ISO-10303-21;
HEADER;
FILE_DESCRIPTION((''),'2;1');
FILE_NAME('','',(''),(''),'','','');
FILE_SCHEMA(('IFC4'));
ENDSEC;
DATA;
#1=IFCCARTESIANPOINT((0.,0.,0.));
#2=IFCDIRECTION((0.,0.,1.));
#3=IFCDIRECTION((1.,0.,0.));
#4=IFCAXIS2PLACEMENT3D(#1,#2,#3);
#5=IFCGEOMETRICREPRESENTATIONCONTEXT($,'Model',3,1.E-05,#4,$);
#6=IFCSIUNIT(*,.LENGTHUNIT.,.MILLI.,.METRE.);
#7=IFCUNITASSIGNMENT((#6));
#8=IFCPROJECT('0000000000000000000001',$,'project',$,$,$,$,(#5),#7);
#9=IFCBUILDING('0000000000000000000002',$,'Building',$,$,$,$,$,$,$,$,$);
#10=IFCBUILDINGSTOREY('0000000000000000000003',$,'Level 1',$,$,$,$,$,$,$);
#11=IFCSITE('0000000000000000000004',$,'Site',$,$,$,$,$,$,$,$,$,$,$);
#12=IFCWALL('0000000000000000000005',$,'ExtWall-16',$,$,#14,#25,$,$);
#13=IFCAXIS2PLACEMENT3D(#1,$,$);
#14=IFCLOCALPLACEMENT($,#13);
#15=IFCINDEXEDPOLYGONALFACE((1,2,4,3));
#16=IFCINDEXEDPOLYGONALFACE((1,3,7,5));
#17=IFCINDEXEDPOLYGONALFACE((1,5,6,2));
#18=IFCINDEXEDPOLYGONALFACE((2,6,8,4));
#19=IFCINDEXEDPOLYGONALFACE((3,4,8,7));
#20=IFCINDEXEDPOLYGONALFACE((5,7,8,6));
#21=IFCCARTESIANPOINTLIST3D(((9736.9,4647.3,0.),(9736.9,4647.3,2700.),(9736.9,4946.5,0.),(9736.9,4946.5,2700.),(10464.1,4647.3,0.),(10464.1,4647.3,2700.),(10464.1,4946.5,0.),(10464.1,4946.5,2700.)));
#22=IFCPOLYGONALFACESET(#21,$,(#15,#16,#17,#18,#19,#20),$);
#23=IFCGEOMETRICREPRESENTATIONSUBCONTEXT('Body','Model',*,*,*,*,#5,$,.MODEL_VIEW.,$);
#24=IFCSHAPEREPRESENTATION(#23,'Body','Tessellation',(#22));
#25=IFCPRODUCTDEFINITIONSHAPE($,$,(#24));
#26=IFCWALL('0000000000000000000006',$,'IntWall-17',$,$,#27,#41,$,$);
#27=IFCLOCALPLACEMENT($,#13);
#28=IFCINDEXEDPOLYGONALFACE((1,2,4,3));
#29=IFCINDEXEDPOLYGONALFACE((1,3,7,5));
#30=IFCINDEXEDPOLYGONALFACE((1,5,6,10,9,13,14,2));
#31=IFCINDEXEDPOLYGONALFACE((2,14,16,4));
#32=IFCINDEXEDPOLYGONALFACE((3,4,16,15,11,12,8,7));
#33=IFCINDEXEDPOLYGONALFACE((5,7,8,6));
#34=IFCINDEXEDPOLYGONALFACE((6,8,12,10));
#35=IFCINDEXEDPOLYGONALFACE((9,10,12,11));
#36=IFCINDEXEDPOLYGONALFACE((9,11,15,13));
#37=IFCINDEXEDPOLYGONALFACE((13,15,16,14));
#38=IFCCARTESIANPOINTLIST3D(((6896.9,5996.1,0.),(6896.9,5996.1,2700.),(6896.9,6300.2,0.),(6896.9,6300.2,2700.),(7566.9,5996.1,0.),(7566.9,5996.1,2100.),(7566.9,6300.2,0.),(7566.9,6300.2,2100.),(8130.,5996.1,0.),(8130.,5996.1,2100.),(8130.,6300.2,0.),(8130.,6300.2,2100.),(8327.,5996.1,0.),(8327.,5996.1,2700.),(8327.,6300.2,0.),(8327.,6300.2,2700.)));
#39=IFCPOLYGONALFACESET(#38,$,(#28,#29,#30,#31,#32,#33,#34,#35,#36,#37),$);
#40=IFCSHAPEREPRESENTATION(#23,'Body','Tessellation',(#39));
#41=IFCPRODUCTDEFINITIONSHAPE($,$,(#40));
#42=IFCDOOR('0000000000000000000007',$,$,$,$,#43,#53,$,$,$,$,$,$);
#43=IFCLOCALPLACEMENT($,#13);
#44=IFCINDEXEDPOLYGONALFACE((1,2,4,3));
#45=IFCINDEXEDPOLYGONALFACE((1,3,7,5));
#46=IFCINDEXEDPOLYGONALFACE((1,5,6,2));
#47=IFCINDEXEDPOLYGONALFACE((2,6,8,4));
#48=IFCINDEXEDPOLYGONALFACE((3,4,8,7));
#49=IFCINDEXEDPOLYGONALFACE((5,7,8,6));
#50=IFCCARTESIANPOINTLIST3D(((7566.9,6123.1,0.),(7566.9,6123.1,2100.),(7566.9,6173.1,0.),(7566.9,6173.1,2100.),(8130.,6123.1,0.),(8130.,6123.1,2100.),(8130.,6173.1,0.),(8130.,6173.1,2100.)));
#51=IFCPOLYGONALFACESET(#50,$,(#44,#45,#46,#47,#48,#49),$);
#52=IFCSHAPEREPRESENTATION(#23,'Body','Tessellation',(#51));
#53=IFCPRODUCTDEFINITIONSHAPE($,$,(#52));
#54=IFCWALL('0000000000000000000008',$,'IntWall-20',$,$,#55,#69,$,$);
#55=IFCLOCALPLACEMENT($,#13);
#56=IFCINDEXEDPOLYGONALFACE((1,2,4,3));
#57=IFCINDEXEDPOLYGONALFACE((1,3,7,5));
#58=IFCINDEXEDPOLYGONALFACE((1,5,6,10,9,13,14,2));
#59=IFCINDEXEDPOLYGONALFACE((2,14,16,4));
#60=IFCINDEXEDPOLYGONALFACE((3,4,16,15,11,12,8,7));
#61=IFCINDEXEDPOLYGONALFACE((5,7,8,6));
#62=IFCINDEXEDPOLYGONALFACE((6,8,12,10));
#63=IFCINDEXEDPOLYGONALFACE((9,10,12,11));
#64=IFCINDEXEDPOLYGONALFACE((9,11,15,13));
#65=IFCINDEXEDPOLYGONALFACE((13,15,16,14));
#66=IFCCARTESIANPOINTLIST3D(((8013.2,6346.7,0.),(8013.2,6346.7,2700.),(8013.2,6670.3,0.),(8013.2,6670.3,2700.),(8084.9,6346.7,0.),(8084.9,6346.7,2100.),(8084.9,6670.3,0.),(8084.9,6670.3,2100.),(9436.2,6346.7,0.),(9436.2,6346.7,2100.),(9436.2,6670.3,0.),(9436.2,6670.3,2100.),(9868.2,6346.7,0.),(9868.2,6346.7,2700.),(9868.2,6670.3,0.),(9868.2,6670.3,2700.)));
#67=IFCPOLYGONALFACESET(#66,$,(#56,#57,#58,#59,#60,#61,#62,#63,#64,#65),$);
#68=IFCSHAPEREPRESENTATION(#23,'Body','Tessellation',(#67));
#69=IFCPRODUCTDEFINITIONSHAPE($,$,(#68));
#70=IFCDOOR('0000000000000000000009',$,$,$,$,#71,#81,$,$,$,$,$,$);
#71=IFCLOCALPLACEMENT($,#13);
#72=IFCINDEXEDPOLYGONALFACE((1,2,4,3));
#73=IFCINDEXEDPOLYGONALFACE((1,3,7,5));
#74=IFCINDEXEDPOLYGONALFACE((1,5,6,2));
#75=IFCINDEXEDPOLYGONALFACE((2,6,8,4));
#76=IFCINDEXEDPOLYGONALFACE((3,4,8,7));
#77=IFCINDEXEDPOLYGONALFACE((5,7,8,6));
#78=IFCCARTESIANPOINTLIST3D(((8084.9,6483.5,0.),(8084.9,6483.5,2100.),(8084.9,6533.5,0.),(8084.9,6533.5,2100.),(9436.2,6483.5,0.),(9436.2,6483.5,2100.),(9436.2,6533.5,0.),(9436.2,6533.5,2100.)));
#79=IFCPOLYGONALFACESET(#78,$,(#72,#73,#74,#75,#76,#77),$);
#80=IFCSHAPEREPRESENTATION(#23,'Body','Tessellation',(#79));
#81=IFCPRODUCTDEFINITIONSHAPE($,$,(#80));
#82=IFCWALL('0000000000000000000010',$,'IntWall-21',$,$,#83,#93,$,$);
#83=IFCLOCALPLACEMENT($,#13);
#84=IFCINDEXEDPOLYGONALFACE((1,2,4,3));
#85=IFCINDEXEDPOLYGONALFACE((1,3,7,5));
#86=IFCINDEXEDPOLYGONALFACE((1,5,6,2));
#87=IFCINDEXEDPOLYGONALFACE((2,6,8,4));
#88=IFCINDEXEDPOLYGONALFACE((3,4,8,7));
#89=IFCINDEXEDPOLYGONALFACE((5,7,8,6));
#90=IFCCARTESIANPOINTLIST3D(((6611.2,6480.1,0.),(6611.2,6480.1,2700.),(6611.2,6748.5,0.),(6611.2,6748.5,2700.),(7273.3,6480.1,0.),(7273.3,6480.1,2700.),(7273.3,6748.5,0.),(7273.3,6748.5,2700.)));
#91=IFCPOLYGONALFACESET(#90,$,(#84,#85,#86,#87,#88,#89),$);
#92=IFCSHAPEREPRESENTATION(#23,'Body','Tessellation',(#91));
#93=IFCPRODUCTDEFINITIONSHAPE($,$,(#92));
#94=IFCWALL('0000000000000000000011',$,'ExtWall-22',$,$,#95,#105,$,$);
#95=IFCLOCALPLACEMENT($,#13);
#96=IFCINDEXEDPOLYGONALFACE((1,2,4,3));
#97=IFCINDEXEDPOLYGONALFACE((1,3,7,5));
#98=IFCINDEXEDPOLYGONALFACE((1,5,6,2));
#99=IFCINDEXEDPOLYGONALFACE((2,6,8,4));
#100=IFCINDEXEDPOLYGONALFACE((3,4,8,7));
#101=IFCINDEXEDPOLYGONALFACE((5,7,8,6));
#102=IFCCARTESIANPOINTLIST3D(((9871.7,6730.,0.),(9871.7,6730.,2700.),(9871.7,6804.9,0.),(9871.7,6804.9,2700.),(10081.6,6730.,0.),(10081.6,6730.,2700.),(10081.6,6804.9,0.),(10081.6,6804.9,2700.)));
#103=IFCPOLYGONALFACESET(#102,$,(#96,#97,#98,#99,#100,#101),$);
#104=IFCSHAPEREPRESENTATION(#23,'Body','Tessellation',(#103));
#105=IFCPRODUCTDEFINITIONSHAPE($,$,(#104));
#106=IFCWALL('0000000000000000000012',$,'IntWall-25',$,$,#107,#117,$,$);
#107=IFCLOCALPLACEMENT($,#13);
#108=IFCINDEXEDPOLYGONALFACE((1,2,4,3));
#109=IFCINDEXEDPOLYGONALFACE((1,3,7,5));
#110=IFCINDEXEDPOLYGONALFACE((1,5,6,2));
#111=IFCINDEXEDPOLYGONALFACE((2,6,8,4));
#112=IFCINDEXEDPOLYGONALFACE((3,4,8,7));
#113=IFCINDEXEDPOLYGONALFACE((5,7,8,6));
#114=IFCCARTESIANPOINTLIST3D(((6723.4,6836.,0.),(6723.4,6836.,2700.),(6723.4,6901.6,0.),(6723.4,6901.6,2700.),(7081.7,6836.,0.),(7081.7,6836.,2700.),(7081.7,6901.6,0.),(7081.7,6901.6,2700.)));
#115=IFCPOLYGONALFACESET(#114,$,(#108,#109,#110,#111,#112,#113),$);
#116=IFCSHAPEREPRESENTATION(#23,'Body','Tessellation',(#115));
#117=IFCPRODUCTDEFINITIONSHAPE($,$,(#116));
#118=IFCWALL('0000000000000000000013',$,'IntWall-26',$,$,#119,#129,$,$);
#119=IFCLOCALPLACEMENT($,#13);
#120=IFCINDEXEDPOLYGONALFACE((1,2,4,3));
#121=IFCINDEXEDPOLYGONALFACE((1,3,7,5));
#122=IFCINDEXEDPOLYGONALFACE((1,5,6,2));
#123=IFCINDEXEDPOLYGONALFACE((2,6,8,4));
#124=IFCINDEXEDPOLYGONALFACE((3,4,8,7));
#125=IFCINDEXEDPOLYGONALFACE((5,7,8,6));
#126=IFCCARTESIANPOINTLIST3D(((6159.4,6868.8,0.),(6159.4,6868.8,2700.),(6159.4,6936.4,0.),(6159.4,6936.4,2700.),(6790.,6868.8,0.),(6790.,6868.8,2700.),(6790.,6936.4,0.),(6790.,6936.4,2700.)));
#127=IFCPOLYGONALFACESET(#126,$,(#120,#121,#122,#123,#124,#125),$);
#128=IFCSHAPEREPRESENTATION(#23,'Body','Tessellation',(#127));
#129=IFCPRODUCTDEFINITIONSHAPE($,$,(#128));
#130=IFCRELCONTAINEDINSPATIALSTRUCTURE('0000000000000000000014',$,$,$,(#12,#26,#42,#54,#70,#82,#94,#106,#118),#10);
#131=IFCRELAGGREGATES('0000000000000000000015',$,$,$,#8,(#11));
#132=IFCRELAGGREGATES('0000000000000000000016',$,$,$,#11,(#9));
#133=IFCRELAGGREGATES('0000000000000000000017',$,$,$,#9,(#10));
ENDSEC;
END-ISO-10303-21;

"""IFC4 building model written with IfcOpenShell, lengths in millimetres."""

from ifc_helpers import new_model, si_unit, frame, origin_with_axes, place, context, subcontext, project, spatial, indexed_curve, outline, extrude, element, fill, save


model = new_model("IFC4")

# Units and contexts
model_context = context("Model", 3, precision=1e-05, world=origin_with_axes())
body_context = subcontext(model_context, "Body", "Model", "MODEL_VIEW")
ifc_project = project(units=[si_unit("LENGTHUNIT", "METRE", prefix="MILLI")], contexts=[model_context])

# Site, building, storey
site = spatial("IfcSite", under=ifc_project, Name="Site")
building = spatial("IfcBuilding", under=site, Name="Building")
storey = spatial("IfcBuildingStorey", under=building, Name="Level 1")

# Wall
wall_1_placement = place(None, frame((9736.9, 4796.9, 0.0), z_axis=(0.0, 0.0, 1.0), x_axis=(1.0, 0.0, 0.0)))
element("IfcWall", 1, at=wall_1_placement, inside=storey, Name="ExtWall-16", context=body_context, shape_type="SweptSolid", body=[
    extrude(outline(indexed_curve([(0.0, 0.0), (0.0, 299.3), (727.2, 299.3), (727.2, 0.0), (0.0, 0.0)], self_intersect=False)), frame((0.0, -149.6, 0.0), z_axis=(0.0, 0.0, 1.0), x_axis=(1.0, 0.0, 0.0)), (0.0, 0.0, 1.0), 2700.0),
])

# Walls, openings, doors
wall_2_placement = place(None, frame((6896.9, 6148.1, 0.0), z_axis=(0.0, 0.0, 1.0), x_axis=(1.0, 0.0, 0.0)))
wall_2 = element("IfcWall", 2, at=wall_2_placement, inside=storey, Name="IntWall-17", context=body_context, shape_type="SweptSolid", body=[
    extrude(outline(indexed_curve([(0.0, 0.0), (0.0, 304.0), (1430.1, 304.0), (1430.1, 0.0), (0.0, 0.0)], self_intersect=False)), frame((0.0, -152.0, 0.0), z_axis=(0.0, 0.0, 1.0), x_axis=(1.0, 0.0, 0.0)), (0.0, 0.0, 1.0), 2700.0),
])
opening_1_placement = place(wall_2_placement, frame((670.0, 0.0, 0.0), z_axis=(0.0, 0.0, 1.0), x_axis=(1.0, 0.0, 0.0)))
opening_1 = element("IfcOpeningElement", 3, at=opening_1_placement, cuts=wall_2, context=body_context, shape_type="SweptSolid", body=[
    extrude(outline(indexed_curve([(0.0, 0.0), (0.0, 404.0), (563.0, 404.0), (563.0, 0.0), (0.0, 0.0)], self_intersect=False)), frame((0.0, -202.0, 0.0), z_axis=(0.0, 0.0, 1.0), x_axis=(1.0, 0.0, 0.0)), (0.0, 0.0, 1.0), 2100.0),
])
door_1_placement = place(opening_1_placement, frame((0.0, 0.0, 0.0), z_axis=(0.0, 0.0, 1.0), x_axis=(1.0, 0.0, 0.0)))
door_1 = element("IfcDoor", 4, at=door_1_placement, inside=storey, context=body_context, shape_type="SweptSolid", body=[
    extrude(outline(indexed_curve([(0.0, 0.0), (0.0, 50.0), (563.0, 50.0), (563.0, 0.0), (0.0, 0.0)], self_intersect=False)), frame((0.0, -25.0, 0.0), z_axis=(0.0, 0.0, 1.0), x_axis=(1.0, 0.0, 0.0)), (0.0, 0.0, 1.0), 2100.0),
])
fill(opening_1, door_1)
wall_3_placement = place(None, frame((8013.2, 6508.5, 0.0), z_axis=(0.0, 0.0, 1.0), x_axis=(1.0, 0.0, 0.0)))
wall_3 = element("IfcWall", 5, at=wall_3_placement, inside=storey, Name="IntWall-20", context=body_context, shape_type="SweptSolid", body=[
    extrude(outline(indexed_curve([(0.0, 0.0), (0.0, 323.6), (1855.0, 323.6), (1855.0, 0.0), (0.0, 0.0)], self_intersect=False)), frame((0.0, -161.8, 0.0), z_axis=(0.0, 0.0, 1.0), x_axis=(1.0, 0.0, 0.0)), (0.0, 0.0, 1.0), 2700.0),
])
opening_2_placement = place(wall_3_placement, frame((71.7, 0.0, 0.0), z_axis=(0.0, 0.0, 1.0), x_axis=(1.0, 0.0, 0.0)))
opening_2 = element("IfcOpeningElement", 6, at=opening_2_placement, cuts=wall_3, context=body_context, shape_type="SweptSolid", body=[
    extrude(outline(indexed_curve([(0.0, 0.0), (0.0, 423.6), (1351.2, 423.6), (1351.2, 0.0), (0.0, 0.0)], self_intersect=False)), frame((0.0, -211.8, 0.0), z_axis=(0.0, 0.0, 1.0), x_axis=(1.0, 0.0, 0.0)), (0.0, 0.0, 1.0), 2100.0),
])
door_2_placement = place(opening_2_placement, origin_with_axes())
door_2 = element("IfcDoor", 7, at=door_2_placement, inside=storey, context=body_context, shape_type="SweptSolid", body=[
    extrude(outline(indexed_curve([(0.0, 0.0), (0.0, 50.0), (1351.2, 50.0), (1351.2, 0.0), (0.0, 0.0)], self_intersect=False)), frame((0.0, -25.0, 0.0), z_axis=(0.0, 0.0, 1.0), x_axis=(1.0, 0.0, 0.0)), (0.0, 0.0, 1.0), 2100.0),
])
fill(opening_2, door_2)

# Walls
wall_4_placement = place(None, frame((6611.2, 6614.3, 0.0), z_axis=(0.0, 0.0, 1.0), x_axis=(1.0, 0.0, 0.0)))
element("IfcWall", 8, at=wall_4_placement, inside=storey, Name="IntWall-21", context=body_context, shape_type="SweptSolid", body=[
    extrude(outline(indexed_curve([(0.0, 0.0), (0.0, 268.4), (662.1, 268.4), (662.1, 0.0), (0.0, 0.0)], self_intersect=False)), frame((0.0, -134.2, 0.0), z_axis=(0.0, 0.0, 1.0), x_axis=(1.0, 0.0, 0.0)), (0.0, 0.0, 1.0), 2700.0),
])
wall_5_placement = place(None, frame((9871.7, 6767.5, 0.0), z_axis=(0.0, 0.0, 1.0), x_axis=(1.0, 0.0, 0.0)))
element("IfcWall", 9, at=wall_5_placement, inside=storey, Name="ExtWall-22", context=body_context, shape_type="SweptSolid", body=[
    extrude(outline(indexed_curve([(0.0, 0.0), (0.0, 74.9), (210.0, 74.9), (210.0, 0.0), (0.0, 0.0)], self_intersect=False)), frame((0.0, -37.4, 0.0), z_axis=(0.0, 0.0, 1.0), x_axis=(1.0, 0.0, 0.0)), (0.0, 0.0, 1.0), 2700.0),
])
wall_6_placement = place(None, frame((6723.4, 6868.8, 0.0), z_axis=(0.0, 0.0, 1.0), x_axis=(1.0, 0.0, 0.0)))
element("IfcWall", 10, at=wall_6_placement, inside=storey, Name="IntWall-25", context=body_context, shape_type="SweptSolid", body=[
    extrude(outline(indexed_curve([(0.0, 0.0), (0.0, 65.5), (358.3, 65.5), (358.3, 0.0), (0.0, 0.0)], self_intersect=False)), frame((0.0, -32.8, 0.0), z_axis=(0.0, 0.0, 1.0), x_axis=(1.0, 0.0, 0.0)), (0.0, 0.0, 1.0), 2700.0),
])
wall_7_placement = place(None, frame((6159.4, 6902.6, 0.0), z_axis=(0.0, 0.0, 1.0), x_axis=(1.0, 0.0, 0.0)))
element("IfcWall", 11, at=wall_7_placement, inside=storey, Name="IntWall-26", context=body_context, shape_type="SweptSolid", body=[
    extrude(outline(indexed_curve([(0.0, 0.0), (0.0, 67.6), (630.6, 67.6), (630.6, 0.0), (0.0, 0.0)], self_intersect=False)), frame((0.0, -33.8, 0.0), z_axis=(0.0, 0.0, 1.0), x_axis=(1.0, 0.0, 0.0)), (0.0, 0.0, 1.0), 2700.0),
])

save(model, "model.ifc")
